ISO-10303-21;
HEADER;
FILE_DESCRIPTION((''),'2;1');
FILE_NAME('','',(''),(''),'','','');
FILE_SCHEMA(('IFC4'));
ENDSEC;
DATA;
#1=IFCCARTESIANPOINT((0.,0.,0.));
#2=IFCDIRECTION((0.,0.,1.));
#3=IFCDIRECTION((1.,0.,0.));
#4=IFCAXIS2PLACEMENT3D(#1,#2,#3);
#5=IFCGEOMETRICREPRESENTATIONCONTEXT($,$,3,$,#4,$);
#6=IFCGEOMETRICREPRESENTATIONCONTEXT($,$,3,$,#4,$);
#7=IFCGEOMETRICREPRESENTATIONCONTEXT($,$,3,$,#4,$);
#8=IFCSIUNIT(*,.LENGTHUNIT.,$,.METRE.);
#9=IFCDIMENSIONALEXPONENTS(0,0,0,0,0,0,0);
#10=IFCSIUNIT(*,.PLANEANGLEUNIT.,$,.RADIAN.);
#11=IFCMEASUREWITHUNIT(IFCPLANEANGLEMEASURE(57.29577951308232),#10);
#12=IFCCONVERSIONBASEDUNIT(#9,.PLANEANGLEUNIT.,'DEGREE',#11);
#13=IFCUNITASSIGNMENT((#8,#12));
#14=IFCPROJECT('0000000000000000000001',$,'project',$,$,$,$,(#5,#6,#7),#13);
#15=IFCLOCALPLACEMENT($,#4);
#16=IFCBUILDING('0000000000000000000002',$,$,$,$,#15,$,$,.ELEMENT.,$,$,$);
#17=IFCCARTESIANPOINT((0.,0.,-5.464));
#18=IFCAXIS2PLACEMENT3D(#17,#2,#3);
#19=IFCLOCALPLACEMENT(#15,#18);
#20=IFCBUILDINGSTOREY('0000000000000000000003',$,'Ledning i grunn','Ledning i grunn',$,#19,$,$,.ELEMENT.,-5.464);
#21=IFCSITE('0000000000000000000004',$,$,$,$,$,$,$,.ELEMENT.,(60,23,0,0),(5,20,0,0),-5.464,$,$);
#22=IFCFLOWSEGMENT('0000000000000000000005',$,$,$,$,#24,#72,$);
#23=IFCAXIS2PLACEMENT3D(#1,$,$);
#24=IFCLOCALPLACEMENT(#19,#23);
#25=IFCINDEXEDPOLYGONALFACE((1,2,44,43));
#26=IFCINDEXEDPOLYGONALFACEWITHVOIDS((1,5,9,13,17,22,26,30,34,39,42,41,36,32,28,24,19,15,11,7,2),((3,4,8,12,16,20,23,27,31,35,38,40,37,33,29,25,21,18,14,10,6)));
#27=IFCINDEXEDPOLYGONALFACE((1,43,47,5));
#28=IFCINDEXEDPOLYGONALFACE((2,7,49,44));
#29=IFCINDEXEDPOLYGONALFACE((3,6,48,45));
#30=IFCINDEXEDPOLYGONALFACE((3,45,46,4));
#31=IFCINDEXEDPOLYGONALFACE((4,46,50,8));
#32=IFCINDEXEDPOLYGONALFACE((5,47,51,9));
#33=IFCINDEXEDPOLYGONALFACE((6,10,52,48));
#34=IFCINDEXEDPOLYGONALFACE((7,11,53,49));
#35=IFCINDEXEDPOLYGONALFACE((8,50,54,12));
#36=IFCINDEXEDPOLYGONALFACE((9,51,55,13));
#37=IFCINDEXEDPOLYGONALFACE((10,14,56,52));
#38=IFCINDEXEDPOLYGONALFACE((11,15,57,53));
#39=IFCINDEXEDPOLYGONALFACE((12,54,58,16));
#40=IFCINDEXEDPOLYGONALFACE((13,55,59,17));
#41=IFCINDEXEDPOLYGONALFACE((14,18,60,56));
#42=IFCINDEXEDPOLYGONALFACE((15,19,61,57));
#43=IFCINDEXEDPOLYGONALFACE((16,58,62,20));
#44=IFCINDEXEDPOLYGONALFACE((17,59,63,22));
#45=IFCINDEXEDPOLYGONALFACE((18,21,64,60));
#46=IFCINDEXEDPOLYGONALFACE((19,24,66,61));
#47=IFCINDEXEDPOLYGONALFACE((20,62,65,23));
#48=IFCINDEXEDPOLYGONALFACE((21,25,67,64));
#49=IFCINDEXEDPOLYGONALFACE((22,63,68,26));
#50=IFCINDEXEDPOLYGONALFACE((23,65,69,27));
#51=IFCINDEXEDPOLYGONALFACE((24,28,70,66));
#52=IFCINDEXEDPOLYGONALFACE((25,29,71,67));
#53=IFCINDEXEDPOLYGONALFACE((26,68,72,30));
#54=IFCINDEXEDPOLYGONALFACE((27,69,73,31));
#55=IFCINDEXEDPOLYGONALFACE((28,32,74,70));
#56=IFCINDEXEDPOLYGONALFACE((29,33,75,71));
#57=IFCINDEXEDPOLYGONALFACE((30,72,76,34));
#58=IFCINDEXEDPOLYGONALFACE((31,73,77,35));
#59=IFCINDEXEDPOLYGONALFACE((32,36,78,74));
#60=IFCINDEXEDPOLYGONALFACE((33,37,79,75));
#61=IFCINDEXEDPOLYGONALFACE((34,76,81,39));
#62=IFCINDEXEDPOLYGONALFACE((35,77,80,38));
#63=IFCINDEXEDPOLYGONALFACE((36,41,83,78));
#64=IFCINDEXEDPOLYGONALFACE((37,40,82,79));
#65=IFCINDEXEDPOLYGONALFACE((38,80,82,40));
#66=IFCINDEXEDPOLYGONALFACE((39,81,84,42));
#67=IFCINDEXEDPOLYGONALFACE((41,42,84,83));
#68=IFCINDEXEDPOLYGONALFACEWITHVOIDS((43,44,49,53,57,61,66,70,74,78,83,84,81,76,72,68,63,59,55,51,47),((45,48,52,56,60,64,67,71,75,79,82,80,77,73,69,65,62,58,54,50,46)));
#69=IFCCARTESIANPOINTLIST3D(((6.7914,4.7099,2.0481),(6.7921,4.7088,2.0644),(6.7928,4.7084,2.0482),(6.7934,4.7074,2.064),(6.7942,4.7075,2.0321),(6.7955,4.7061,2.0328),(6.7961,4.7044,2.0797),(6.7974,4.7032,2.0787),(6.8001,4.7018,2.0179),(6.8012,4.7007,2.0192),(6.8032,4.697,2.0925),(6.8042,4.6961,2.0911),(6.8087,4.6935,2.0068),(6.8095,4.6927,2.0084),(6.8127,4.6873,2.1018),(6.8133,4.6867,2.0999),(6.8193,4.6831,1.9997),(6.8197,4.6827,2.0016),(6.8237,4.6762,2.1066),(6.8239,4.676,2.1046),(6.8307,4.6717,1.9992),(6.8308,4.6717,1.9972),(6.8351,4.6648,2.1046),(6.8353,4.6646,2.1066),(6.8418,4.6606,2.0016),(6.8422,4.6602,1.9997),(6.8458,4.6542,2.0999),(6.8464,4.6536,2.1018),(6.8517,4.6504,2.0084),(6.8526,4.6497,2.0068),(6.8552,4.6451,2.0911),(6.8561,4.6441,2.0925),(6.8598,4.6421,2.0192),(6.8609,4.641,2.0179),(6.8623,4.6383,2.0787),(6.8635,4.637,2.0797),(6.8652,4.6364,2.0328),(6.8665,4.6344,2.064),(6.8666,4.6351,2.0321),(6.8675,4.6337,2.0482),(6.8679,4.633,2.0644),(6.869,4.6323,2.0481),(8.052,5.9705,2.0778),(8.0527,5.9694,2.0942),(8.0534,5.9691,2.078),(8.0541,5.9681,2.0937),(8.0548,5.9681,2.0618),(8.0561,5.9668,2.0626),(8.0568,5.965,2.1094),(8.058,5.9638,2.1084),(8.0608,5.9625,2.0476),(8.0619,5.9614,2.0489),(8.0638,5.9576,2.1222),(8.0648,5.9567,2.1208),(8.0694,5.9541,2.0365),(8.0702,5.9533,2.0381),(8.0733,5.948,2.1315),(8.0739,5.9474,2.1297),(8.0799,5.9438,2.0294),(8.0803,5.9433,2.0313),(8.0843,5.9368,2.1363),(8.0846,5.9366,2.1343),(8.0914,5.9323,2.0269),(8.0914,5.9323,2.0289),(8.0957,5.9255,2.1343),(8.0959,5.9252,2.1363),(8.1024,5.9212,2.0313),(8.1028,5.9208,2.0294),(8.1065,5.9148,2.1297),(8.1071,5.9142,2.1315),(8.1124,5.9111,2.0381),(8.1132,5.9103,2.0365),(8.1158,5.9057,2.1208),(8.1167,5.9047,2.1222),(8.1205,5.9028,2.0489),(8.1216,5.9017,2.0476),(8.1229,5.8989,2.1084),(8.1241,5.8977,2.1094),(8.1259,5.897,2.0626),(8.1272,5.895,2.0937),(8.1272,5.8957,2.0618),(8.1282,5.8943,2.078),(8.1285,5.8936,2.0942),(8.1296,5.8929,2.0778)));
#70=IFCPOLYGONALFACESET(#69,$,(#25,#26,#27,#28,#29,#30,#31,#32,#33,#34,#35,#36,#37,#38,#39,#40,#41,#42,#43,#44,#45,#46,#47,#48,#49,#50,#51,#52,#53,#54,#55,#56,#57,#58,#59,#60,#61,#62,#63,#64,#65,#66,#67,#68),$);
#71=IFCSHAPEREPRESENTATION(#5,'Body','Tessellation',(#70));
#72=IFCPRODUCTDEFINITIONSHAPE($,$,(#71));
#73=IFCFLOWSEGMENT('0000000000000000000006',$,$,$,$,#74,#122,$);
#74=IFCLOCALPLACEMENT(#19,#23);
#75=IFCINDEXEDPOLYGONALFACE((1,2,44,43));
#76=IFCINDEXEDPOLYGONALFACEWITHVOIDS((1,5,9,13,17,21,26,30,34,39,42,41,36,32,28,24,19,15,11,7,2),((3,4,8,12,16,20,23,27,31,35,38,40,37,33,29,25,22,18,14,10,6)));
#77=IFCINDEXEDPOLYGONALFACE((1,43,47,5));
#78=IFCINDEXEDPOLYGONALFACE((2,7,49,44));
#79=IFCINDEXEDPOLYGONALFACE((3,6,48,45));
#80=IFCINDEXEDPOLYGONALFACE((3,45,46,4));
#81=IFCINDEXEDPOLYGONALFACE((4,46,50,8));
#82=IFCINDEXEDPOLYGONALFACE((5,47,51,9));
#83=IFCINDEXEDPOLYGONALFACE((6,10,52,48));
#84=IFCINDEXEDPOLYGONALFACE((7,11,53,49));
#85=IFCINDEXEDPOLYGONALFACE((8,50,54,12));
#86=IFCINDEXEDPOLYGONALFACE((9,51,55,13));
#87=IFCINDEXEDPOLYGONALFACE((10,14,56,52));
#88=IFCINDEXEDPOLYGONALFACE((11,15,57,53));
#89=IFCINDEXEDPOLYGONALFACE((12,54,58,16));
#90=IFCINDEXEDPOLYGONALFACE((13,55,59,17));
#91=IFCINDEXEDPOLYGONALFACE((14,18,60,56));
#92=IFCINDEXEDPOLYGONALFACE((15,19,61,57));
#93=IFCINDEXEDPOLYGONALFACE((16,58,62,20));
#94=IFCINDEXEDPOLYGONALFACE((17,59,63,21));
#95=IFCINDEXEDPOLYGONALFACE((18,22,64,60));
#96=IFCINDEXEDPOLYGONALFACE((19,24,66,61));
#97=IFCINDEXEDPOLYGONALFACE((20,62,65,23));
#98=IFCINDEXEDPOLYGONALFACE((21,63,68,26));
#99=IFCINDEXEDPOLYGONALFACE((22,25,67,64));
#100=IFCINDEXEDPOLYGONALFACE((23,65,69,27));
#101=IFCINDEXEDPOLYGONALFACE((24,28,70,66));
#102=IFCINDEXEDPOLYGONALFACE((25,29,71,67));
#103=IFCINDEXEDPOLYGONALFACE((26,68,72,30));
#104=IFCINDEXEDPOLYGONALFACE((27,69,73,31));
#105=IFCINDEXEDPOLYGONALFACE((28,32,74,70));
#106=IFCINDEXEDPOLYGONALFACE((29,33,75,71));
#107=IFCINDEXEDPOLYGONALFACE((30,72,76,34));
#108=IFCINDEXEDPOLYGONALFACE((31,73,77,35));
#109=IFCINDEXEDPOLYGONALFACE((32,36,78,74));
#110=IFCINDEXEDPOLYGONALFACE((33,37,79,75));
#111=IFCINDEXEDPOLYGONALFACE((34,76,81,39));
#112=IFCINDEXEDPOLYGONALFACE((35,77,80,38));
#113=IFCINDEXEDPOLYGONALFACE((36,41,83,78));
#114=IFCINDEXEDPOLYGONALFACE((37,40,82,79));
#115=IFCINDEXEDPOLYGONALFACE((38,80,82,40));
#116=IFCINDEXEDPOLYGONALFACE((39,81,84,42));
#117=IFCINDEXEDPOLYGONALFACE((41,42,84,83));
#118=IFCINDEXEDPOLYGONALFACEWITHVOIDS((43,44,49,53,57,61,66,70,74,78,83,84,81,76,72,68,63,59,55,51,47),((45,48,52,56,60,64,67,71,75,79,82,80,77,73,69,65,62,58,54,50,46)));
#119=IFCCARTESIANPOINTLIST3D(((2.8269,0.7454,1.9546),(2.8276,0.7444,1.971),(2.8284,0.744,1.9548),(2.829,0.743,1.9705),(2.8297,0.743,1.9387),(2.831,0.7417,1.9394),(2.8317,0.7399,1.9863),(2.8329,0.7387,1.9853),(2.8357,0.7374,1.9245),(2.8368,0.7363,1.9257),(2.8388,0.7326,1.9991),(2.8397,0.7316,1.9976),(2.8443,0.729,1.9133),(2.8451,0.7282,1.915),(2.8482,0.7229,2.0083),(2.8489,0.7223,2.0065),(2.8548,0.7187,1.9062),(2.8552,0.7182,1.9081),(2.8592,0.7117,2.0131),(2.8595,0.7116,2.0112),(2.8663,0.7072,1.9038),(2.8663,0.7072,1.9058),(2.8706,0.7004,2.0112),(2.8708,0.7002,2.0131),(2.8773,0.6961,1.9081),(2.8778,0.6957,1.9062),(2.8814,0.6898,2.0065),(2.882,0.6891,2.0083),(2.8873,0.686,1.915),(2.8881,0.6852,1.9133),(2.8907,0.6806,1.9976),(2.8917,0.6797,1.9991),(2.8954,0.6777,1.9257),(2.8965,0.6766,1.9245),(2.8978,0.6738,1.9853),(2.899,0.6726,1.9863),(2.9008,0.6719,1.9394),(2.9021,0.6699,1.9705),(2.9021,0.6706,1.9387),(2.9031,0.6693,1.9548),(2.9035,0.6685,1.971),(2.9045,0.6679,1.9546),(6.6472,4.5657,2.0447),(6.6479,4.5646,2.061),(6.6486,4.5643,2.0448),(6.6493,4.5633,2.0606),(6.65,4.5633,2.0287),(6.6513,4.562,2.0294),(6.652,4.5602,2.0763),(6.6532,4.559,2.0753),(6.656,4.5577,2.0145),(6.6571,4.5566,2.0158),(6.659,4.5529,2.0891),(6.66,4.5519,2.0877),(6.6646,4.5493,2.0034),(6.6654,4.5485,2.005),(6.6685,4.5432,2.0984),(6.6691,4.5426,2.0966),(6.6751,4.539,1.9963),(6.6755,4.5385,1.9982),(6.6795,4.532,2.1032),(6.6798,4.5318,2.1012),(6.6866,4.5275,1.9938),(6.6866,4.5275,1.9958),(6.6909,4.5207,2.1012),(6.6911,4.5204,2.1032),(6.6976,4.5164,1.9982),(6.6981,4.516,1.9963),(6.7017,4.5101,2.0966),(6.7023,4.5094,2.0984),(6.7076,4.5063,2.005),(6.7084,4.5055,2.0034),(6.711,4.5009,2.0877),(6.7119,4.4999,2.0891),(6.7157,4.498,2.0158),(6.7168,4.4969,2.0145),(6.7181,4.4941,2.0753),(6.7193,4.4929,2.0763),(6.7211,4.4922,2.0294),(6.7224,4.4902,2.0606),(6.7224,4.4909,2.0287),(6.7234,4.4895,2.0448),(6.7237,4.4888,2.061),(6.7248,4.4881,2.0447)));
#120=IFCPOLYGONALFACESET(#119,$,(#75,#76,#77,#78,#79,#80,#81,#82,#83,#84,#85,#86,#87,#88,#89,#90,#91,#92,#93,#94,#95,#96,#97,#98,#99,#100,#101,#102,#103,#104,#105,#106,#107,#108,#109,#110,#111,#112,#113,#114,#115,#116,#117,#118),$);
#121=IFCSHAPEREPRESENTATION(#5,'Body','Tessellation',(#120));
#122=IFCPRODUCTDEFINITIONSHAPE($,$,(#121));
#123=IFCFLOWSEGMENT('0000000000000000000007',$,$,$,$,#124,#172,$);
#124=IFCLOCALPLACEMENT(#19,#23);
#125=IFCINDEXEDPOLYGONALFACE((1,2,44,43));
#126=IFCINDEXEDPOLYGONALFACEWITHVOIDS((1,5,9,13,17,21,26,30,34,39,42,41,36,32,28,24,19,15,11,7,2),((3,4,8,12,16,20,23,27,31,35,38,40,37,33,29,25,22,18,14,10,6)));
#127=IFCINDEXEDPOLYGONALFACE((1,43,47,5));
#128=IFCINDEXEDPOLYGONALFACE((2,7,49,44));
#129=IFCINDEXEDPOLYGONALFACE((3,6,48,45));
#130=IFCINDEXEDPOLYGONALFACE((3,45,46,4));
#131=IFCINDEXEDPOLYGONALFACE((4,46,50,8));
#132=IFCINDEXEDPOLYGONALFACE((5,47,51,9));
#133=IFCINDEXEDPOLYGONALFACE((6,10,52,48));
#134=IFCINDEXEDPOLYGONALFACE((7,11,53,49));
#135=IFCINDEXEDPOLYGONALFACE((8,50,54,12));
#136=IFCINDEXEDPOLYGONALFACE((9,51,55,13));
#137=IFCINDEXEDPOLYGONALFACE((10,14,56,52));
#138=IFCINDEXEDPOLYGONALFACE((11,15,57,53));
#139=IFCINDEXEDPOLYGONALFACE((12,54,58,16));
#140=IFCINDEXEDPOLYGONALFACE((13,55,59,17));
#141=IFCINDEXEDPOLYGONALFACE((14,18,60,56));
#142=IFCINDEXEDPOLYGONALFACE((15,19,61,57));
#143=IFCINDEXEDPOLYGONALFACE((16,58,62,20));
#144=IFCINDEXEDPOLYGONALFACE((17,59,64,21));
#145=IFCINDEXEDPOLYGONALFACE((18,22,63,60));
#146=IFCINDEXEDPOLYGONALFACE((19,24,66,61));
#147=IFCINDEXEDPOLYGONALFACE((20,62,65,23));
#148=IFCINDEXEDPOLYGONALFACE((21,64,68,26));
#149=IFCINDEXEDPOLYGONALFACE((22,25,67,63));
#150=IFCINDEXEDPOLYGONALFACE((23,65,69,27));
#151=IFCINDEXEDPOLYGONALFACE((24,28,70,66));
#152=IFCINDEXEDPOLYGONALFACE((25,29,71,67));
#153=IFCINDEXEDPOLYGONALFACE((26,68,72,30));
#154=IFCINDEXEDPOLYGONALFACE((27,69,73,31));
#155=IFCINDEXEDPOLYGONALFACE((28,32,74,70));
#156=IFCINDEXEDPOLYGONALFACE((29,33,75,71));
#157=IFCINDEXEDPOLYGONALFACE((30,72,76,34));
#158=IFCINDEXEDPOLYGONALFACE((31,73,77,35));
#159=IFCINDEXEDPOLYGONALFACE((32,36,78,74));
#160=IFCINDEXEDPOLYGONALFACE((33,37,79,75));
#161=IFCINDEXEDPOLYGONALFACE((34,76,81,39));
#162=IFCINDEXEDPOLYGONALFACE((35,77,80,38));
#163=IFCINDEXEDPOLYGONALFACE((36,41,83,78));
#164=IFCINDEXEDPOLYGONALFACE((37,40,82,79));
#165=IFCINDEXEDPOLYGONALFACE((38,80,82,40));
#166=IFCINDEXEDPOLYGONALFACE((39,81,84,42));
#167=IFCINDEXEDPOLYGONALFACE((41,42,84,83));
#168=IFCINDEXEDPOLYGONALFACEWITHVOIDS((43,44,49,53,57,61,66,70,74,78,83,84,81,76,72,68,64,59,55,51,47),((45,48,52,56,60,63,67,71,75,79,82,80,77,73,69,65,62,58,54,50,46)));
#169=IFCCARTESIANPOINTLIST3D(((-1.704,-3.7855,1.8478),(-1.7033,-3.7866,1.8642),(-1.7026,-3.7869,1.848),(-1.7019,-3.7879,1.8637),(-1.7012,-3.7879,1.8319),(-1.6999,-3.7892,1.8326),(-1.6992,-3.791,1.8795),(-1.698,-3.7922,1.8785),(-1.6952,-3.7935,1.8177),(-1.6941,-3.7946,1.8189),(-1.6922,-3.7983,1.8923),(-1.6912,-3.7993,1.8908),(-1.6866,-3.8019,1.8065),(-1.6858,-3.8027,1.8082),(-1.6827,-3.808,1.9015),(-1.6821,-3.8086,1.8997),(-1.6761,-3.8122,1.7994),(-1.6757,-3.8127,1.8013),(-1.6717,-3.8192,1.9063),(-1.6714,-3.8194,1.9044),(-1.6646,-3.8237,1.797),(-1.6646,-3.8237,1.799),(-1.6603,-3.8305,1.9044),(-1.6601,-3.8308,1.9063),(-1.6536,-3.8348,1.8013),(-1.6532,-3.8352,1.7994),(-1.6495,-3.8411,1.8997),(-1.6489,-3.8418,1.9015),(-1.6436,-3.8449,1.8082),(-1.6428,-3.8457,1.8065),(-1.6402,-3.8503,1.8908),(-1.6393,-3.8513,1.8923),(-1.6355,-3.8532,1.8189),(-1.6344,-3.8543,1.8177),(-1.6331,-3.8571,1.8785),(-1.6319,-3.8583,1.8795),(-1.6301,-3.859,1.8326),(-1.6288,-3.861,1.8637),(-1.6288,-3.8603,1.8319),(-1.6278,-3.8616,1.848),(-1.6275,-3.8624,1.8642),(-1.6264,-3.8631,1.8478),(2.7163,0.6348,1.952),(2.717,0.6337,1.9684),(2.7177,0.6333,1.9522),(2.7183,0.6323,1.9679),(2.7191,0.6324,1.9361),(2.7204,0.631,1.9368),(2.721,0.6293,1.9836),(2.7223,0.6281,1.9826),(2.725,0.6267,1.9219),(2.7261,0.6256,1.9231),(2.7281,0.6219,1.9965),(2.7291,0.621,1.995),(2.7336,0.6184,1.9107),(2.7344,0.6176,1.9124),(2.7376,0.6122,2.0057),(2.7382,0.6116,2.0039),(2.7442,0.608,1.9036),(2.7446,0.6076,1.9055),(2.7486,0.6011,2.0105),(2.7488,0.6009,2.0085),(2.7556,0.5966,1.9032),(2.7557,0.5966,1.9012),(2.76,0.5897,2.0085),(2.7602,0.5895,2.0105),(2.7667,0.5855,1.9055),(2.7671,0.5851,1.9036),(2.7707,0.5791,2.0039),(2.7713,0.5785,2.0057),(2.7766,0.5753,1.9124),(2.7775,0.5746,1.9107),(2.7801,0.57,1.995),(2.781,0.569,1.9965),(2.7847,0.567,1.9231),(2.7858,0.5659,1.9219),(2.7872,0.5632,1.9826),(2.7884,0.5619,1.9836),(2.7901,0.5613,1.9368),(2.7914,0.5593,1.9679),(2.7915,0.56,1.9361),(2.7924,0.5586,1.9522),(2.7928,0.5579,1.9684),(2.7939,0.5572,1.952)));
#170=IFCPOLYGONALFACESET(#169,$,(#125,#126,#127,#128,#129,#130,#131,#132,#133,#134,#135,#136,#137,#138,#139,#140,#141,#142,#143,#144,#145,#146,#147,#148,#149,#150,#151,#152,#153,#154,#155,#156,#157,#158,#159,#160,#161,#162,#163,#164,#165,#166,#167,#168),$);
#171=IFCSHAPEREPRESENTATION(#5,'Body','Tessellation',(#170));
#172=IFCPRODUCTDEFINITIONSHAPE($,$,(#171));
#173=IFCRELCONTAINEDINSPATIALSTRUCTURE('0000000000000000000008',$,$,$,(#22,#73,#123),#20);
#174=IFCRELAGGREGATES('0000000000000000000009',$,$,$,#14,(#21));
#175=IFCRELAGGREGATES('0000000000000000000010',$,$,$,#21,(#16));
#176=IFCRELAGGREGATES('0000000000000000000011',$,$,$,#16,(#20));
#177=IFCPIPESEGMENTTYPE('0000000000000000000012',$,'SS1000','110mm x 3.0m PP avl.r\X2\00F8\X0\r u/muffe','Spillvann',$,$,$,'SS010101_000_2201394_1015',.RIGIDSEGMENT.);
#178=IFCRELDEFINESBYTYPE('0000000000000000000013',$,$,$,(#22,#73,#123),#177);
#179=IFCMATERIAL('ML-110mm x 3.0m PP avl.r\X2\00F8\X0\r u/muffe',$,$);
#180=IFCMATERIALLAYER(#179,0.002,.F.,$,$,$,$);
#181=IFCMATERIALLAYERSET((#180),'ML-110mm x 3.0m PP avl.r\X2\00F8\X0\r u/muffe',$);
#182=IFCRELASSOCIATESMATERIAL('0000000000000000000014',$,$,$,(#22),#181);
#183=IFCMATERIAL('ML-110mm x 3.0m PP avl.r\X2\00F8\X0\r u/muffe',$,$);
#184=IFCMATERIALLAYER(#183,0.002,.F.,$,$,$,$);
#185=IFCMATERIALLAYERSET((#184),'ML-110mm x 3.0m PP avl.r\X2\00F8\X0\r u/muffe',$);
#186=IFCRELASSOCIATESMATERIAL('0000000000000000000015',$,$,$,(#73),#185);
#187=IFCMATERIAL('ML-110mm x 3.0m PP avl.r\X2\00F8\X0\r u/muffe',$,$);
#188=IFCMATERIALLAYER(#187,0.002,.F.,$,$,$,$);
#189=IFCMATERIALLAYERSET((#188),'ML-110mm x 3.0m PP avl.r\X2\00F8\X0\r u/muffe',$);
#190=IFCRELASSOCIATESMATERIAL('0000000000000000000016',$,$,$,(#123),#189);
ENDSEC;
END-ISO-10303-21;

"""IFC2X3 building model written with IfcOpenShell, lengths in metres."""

from ifc_helpers import new_model, entity, si_unit, converted_unit, frame, origin_with_axes, origin_2d_with_axis, place, context, project, spatial, hollow_circle, extrude, material, layer, layer_set, layer_usage, type_object, element, save


model = new_model("IFC2X3")

# Units and contexts
context_of_model_1 = context(None, 3, world=origin_with_axes())
context_of_model_2 = context(None, 3, world=origin_with_axes())
context_of_model_3 = context(None, 3, world=origin_with_axes())
ifc_project = project(units=[si_unit("LENGTHUNIT", "METRE"), converted_unit("PLANEANGLEUNIT", "DEGREE", entity("IfcPlaneAngleMeasure", 57.29577951308232), si_unit("PLANEANGLEUNIT", "RADIAN"), dimensions=[0, 0, 0, 0, 0, 0, 0])], contexts=[context_of_model_1, context_of_model_2, context_of_model_3])

# Site, building, storey
site = spatial("IfcSite", under=ifc_project, CompositionType="ELEMENT", RefLatitude=(60, 23, 0, 0), RefLongitude=(5, 20, 0, 0), RefElevation=-5.464)
building_placement = place(None, origin_with_axes())
building = spatial("IfcBuilding", under=site, at=building_placement, CompositionType="ELEMENT")
storey_placement = place(building_placement, frame((0.0, 0.0, -5.464), z_axis=(0.0, 0.0, 1.0), x_axis=(1.0, 0.0, 0.0)))
storey = spatial("IfcBuildingStorey", under=building, at=storey_placement, Name="Ledning i grunn", Description="Ledning i grunn", CompositionType="ELEMENT", Elevation=-5.464)

# Flow segments
pipe_segment_type_1 = type_object("IfcPipeSegmentType", Name="SS1000", Description="110mm x 3.0m PP avl.rør u/muffe", ApplicableOccurrence="Spillvann", ElementType="SS010101_000_2201394_1015", PredefinedType="RIGIDSEGMENT")
ifc_material_1 = material(Name="ML-110mm x 3.0m PP avl.rør u/muffe")
ifc_layer_1 = layer(ifc_material_1, 0.002, ventilated=False)
ifc_layer_set_1 = layer_set([ifc_layer_1], Name="ML-110mm x 3.0m PP avl.rør u/muffe")
ifc_layer_usage_1 = layer_usage(ifc_layer_set_1, "AXIS2", "POSITIVE", 0.0)
flow_segment_1_placement = place(storey_placement, frame((8.0908, 5.9317, 2.0819), z_axis=(-0.707009, -0.707008, -0.016665), x_axis=(0.011784, 0.011784, -0.999861)))
element("IfcFlowSegment", 1, at=flow_segment_1_placement, inside=storey, type_object=pipe_segment_type_1, material=ifc_layer_usage_1, context=context_of_model_1, shape_type="SweptSolid", body=[
    extrude(hollow_circle(Radius=0.055, WallThickness=0.002, at=origin_2d_with_axis()), origin_with_axes(), (0.0, 0.0, 1.0), 1.7831),
])
ifc_material_2 = material(Name="ML-110mm x 3.0m PP avl.rør u/muffe")
ifc_layer_2 = layer(ifc_material_2, 0.002, ventilated=False)
ifc_layer_set_2 = layer_set([ifc_layer_2], Name="ML-110mm x 3.0m PP avl.rør u/muffe")
ifc_layer_usage_2 = layer_usage(ifc_layer_set_2, "AXIS2", "POSITIVE", 0.0)
flow_segment_2_placement = place(storey_placement, frame((6.686, 4.5269, 2.0488), z_axis=(-0.707009, -0.707008, -0.016665), x_axis=(0.011784, 0.011784, -0.999861)))
element("IfcFlowSegment", 2, at=flow_segment_2_placement, inside=storey, type_object=pipe_segment_type_1, material=ifc_layer_usage_2, context=context_of_model_1, shape_type="SweptSolid", body=[
    extrude(hollow_circle(Radius=0.055, WallThickness=0.002, at=origin_2d_with_axis()), origin_with_axes(), (0.0, 0.0, 1.0), 5.4035),
])
ifc_material_3 = material(Name="ML-110mm x 3.0m PP avl.rør u/muffe")
ifc_layer_3 = layer(ifc_material_3, 0.002, ventilated=False)
ifc_layer_set_3 = layer_set([ifc_layer_3], Name="ML-110mm x 3.0m PP avl.rør u/muffe")
ifc_layer_usage_3 = layer_usage(ifc_layer_set_3, "AXIS2", "POSITIVE", 0.0)
flow_segment_3_placement = place(storey_placement, frame((2.755, 0.5959, 1.9561), z_axis=(-0.707009, -0.707008, -0.016665), x_axis=(0.011784, 0.011784, -0.999861)))
element("IfcFlowSegment", 3, at=flow_segment_3_placement, inside=storey, type_object=pipe_segment_type_1, material=ifc_layer_usage_3, context=context_of_model_1, shape_type="SweptSolid", body=[
    extrude(hollow_circle(Radius=0.055, WallThickness=0.002, at=origin_2d_with_axis()), origin_with_axes(), (0.0, 0.0, 1.0), 6.2521),
])

save(model, "model.ifc")
